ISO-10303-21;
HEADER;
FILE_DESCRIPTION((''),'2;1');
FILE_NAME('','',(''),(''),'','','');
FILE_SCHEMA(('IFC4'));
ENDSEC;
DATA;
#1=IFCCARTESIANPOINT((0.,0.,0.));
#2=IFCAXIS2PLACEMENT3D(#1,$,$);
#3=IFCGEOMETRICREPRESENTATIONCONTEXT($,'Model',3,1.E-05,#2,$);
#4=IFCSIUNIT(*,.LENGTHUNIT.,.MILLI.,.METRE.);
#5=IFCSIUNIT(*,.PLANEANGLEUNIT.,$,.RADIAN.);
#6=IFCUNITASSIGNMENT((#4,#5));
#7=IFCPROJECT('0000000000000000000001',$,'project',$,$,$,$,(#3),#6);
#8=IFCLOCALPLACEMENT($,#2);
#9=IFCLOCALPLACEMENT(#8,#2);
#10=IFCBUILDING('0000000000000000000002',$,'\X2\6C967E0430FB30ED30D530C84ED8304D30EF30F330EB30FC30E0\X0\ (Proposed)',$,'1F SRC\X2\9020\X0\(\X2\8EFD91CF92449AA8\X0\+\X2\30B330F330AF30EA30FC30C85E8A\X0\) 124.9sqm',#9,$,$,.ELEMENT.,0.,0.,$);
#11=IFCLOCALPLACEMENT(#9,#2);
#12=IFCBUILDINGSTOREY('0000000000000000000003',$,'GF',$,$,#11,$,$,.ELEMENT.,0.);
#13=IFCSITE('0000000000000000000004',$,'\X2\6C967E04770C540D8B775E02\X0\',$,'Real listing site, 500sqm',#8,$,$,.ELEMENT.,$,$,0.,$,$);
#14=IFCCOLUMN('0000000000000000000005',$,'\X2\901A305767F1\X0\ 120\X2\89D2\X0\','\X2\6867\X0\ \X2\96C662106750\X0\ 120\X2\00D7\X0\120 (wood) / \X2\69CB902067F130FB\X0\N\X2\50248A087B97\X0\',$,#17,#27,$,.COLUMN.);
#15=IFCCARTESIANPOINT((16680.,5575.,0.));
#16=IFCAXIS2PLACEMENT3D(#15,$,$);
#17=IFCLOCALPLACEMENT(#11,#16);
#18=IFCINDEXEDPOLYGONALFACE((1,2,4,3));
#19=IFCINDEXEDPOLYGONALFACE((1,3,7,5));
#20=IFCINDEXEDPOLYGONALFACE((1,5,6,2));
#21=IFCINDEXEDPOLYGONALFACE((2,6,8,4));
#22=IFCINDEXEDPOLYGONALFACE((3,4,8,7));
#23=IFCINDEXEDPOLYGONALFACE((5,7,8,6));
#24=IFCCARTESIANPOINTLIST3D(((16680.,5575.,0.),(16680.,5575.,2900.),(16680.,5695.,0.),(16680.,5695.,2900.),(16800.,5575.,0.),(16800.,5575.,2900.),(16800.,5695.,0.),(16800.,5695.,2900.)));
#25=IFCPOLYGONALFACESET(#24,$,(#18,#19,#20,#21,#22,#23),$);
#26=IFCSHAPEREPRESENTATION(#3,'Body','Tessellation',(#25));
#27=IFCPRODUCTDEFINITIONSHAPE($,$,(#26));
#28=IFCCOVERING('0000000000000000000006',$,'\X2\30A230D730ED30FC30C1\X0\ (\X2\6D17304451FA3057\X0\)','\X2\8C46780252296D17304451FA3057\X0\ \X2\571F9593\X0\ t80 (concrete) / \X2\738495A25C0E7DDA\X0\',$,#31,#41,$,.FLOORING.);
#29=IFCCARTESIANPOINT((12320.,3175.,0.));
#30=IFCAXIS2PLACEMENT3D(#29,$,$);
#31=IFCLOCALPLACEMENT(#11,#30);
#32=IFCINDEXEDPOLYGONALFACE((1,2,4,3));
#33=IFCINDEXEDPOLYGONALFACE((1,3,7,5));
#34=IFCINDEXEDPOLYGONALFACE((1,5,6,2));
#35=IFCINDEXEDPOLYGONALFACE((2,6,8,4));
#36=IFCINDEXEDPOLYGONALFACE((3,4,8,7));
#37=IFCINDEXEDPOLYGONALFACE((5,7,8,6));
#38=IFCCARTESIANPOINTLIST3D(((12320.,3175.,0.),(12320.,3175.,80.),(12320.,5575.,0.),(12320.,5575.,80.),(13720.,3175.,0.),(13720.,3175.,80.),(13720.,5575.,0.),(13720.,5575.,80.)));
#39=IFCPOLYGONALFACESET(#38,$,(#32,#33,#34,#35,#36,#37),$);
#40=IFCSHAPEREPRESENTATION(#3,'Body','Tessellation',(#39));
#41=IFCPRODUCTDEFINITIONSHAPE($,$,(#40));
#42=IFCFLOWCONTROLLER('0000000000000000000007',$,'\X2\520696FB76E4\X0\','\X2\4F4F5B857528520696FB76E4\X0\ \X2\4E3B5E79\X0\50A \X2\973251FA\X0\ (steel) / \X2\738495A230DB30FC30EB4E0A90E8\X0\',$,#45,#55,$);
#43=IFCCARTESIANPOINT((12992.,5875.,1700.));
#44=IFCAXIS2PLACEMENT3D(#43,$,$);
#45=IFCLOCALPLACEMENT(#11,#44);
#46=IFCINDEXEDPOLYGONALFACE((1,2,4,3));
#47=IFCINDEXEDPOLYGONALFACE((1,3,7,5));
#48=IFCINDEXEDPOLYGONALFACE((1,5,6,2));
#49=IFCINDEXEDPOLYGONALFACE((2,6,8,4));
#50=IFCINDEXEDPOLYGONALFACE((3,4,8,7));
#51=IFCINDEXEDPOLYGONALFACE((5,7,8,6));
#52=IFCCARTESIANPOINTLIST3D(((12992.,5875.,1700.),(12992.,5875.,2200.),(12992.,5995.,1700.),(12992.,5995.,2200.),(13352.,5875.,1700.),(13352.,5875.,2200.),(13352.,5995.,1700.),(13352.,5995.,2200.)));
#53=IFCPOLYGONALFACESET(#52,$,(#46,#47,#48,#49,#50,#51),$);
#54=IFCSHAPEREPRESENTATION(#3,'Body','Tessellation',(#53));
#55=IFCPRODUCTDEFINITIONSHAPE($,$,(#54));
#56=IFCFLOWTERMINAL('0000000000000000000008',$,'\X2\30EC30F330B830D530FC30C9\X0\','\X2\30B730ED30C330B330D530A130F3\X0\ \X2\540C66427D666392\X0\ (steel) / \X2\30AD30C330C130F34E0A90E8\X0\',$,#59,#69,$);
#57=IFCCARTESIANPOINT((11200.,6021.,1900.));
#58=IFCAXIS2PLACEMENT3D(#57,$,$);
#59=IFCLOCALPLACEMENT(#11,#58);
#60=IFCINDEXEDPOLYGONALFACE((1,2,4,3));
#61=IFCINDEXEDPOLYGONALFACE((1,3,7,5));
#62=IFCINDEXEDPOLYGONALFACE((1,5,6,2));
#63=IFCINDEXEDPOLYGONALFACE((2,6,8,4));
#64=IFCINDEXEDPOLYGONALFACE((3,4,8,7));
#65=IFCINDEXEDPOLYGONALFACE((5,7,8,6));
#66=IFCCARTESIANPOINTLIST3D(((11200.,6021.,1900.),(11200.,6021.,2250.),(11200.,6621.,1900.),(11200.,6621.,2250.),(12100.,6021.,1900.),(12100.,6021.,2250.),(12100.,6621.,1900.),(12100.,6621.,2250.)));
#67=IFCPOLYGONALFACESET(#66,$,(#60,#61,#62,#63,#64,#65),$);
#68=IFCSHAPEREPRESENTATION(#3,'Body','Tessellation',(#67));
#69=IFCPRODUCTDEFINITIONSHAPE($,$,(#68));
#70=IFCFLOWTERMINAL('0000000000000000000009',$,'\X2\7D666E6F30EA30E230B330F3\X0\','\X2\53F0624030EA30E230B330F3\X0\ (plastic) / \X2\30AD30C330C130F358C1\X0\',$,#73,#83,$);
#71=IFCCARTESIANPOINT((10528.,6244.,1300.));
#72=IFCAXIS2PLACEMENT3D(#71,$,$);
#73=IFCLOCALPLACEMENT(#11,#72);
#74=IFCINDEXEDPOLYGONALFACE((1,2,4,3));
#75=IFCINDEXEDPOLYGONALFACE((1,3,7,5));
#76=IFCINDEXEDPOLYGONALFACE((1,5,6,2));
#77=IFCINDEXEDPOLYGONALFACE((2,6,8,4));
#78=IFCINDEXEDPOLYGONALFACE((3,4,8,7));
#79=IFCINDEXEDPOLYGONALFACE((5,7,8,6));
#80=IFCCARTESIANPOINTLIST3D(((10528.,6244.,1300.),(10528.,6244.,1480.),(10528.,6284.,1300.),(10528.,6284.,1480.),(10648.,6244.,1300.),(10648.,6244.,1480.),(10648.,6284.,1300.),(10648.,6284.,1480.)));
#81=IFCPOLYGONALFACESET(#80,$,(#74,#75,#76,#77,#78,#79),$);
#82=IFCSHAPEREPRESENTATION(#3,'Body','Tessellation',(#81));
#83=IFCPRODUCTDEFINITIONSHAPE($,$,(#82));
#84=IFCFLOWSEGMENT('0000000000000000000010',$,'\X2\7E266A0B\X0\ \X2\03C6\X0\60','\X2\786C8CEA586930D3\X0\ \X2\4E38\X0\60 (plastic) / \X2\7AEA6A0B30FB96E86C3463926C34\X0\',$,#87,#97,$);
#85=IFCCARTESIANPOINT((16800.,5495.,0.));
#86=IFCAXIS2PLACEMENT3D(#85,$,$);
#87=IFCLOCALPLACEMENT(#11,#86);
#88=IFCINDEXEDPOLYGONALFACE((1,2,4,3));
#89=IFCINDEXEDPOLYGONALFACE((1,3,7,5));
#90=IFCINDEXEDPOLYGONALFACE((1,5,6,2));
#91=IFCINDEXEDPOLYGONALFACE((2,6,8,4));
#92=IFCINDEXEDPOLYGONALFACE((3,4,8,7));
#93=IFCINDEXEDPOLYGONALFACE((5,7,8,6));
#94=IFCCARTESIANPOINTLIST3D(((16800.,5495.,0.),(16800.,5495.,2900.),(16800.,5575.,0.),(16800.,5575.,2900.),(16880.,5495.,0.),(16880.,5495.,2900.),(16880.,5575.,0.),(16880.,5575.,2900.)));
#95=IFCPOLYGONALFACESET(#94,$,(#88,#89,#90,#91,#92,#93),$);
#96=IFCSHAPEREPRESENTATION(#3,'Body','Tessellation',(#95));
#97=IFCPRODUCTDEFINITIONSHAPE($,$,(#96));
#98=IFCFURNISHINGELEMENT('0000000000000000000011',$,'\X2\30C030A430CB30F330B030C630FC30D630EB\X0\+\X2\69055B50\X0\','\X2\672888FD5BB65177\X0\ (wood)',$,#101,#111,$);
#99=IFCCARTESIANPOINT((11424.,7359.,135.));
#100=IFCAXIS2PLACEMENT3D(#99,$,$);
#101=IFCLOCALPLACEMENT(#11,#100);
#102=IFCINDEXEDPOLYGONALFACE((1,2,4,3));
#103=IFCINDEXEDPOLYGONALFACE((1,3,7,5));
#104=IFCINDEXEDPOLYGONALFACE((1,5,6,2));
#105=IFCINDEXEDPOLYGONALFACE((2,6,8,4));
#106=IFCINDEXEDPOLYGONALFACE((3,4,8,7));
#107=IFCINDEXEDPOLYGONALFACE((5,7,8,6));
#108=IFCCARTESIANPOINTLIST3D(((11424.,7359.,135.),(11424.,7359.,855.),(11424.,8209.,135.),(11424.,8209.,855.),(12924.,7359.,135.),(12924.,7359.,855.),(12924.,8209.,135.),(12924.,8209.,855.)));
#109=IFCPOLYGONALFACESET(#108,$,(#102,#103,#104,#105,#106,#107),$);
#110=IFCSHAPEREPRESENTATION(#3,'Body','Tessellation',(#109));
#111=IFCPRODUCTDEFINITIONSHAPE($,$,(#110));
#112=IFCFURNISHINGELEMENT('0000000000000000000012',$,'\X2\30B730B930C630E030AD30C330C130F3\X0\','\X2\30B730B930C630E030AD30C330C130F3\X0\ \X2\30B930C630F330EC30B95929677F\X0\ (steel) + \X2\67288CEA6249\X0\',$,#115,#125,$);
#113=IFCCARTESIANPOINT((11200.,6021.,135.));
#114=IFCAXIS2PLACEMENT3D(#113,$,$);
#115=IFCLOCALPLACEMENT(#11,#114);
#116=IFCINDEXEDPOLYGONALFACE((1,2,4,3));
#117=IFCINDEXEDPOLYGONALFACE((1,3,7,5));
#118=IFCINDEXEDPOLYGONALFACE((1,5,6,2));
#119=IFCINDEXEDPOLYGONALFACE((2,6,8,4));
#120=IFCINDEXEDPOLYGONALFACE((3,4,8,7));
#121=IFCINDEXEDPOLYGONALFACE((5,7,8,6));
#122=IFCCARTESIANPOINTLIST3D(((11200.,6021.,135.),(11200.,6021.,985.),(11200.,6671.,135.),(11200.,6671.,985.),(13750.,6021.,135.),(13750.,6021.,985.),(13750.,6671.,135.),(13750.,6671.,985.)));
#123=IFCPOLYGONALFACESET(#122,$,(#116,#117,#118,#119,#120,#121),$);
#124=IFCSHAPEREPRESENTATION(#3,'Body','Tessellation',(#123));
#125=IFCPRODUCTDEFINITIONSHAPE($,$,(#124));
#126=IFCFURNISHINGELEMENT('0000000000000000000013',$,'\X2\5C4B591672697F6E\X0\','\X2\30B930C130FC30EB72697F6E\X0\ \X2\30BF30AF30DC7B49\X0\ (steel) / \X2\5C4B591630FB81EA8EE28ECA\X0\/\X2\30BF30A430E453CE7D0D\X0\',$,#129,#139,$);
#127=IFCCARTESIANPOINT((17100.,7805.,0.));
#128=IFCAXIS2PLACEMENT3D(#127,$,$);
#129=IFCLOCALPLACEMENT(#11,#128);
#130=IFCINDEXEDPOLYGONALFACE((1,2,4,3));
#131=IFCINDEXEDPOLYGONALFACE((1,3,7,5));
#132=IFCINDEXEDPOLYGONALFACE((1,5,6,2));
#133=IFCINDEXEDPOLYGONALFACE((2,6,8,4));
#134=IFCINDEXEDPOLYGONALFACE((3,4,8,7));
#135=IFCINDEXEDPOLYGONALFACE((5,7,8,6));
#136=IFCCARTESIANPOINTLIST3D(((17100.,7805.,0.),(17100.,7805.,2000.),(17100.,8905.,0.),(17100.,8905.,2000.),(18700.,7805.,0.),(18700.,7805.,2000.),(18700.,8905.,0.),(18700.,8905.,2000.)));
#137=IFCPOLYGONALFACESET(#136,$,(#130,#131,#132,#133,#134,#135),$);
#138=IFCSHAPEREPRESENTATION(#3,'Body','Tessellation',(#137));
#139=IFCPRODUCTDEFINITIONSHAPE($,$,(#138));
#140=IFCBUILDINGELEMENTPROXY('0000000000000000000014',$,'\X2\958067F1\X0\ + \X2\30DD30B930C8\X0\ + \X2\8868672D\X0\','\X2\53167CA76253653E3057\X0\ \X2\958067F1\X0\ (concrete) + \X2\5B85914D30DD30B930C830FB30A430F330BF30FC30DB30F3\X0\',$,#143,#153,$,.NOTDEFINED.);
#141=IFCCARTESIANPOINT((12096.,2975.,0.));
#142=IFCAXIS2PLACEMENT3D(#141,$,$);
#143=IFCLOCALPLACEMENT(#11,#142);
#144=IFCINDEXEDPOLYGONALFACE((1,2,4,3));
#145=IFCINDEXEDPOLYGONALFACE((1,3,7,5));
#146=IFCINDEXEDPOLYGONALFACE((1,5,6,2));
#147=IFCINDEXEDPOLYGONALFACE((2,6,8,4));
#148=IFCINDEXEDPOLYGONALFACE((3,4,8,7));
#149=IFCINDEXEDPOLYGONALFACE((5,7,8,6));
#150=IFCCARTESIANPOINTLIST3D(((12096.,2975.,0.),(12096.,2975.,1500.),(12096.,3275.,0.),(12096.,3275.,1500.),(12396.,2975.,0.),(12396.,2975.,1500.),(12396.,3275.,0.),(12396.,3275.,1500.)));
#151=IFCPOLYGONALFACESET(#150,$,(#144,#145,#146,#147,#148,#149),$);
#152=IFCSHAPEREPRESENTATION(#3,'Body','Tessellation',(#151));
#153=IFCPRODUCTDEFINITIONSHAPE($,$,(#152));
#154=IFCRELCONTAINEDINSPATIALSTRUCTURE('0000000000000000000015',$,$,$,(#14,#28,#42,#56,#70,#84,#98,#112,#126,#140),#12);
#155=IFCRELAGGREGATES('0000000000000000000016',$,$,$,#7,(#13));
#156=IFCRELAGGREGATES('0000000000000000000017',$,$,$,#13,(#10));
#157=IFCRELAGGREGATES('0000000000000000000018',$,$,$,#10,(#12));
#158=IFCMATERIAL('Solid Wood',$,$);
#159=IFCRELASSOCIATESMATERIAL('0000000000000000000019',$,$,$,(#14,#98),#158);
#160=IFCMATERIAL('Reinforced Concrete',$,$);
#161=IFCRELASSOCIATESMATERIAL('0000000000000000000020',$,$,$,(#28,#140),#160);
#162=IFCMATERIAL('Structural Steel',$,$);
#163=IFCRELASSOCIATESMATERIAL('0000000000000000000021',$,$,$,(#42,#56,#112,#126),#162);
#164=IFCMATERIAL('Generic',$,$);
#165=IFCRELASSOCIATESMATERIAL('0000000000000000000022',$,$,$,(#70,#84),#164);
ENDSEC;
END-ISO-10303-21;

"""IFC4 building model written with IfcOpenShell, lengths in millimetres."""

from ifc_helpers import new_model, si_unit, frame, frame_2d, origin, place, context, project, spatial, rectangle, extrude, material, element, save


model = new_model("IFC4")

# Units and contexts
model_context = context("Model", 3, precision=1e-05, world=origin())
ifc_project = project(units=[si_unit("LENGTHUNIT", "METRE", prefix="MILLI"), si_unit("PLANEANGLEUNIT", "RADIAN")], contexts=[model_context])

# Site, building, storey
site_placement = place(None, origin())
site = spatial("IfcSite", under=ifc_project, at=site_placement, Name="沖縄県名護市", ObjectType="Real listing site, 500sqm", CompositionType="ELEMENT", RefElevation=0.0)
building_placement = place(site_placement, origin())
building = spatial("IfcBuilding", under=site, at=building_placement, Name="沖縄・ロフト付きワンルーム (Proposed)", ObjectType="1F SRC造(軽量鉄骨+コンクリート床) 124.9sqm", CompositionType="ELEMENT", ElevationOfRefHeight=0.0, ElevationOfTerrain=0.0)
storey_placement = place(building_placement, origin())
storey = spatial("IfcBuildingStorey", under=building, at=storey_placement, Name="GF", CompositionType="ELEMENT", Elevation=0.0)

# Column
ifc_material_1 = material(Name="Solid Wood")
column_1_placement = place(storey_placement, frame((16680.0, 5575.0, 0.0)))
element("IfcColumn", 1, at=column_1_placement, inside=storey, material=ifc_material_1, Name="通し柱 120角", Description="桧 集成材 120×120 (wood) / 構造柱・N値計算", PredefinedType="COLUMN", context=model_context, shape_type="SweptSolid", body=[
    extrude(rectangle(XDim=120.0, YDim=120.0, at=frame_2d((60.0, 60.0))), frame((16680.0, 5575.0, 0.0)), (0.0, 0.0, 1.0), 2900.0),
])

# Covering
ifc_material_2 = material(Name="Reinforced Concrete")
covering_placement = place(storey_placement, frame((12320.0, 3175.0, 0.0)))
element("IfcCovering", 2, at=covering_placement, inside=storey, material=ifc_material_2, Name="アプローチ (洗い出し)", Description="豆砂利洗い出し 土間 t80 (concrete) / 玄関導線", PredefinedType="FLOORING", context=model_context, shape_type="SweptSolid", body=[
    extrude(rectangle(XDim=1400.0, YDim=2400.0, at=frame_2d((700.0, 1200.0))), frame((12320.0, 3175.0, 0.0)), (0.0, 0.0, 1.0), 80.0),
])

# Flow controller
ifc_material_3 = material(Name="Structural Steel")
flow_controller_placement = place(storey_placement, frame((12992.0, 5875.0, 1700.0)))
element("IfcFlowController", 3, at=flow_controller_placement, inside=storey, material=ifc_material_3, Name="分電盤", Description="住宅用分電盤 主幹50A 露出 (steel) / 玄関ホール上部", context=model_context, shape_type="SweptSolid", body=[
    extrude(rectangle(XDim=360.0, YDim=120.0, at=frame_2d((180.0, 60.0))), frame((12992.0, 5875.0, 1700.0)), (0.0, 0.0, 1.0), 500.0),
])

# Flow terminals
flow_terminal_1_placement = place(storey_placement, frame((11200.0, 6021.0, 1900.0)))
element("IfcFlowTerminal", 4, at=flow_terminal_1_placement, inside=storey, material=ifc_material_3, Name="レンジフード", Description="シロッコファン 同時給排 (steel) / キッチン上部", context=model_context, shape_type="SweptSolid", body=[
    extrude(rectangle(XDim=900.0, YDim=600.0, at=frame_2d((450.0, 300.0))), frame((11200.0, 6021.0, 1900.0)), (0.0, 0.0, 1.0), 350.0),
])
ifc_material_4 = material(Name="Generic")
flow_terminal_2_placement = place(storey_placement, frame((10528.0, 6244.0, 1300.0)))
element("IfcFlowTerminal", 5, at=flow_terminal_2_placement, inside=storey, material=ifc_material_4, Name="給湯リモコン", Description="台所リモコン (plastic) / キッチン壁", context=model_context, shape_type="SweptSolid", body=[
    extrude(rectangle(XDim=120.0, YDim=40.0, at=frame_2d((60.0, 20.0))), frame((10528.0, 6244.0, 1300.0)), (0.0, 0.0, 1.0), 180.0),
])

# Flow segment
flow_segment_placement = place(storey_placement, frame((16800.0, 5495.0, 0.0)))
element("IfcFlowSegment", 6, at=flow_segment_placement, inside=storey, material=ifc_material_4, Name="縦樋 φ60", Description="硬質塩ビ 丸60 (plastic) / 竪樋・雨水排水", context=model_context, shape_type="SweptSolid", body=[
    extrude(rectangle(XDim=80.0, YDim=80.0, at=frame_2d((40.0, 40.0))), frame((16800.0, 5495.0, 0.0)), (0.0, 0.0, 1.0), 2900.0),
])

# Furnishing elements
furnishing_1_placement = place(storey_placement, frame((11424.0, 7359.0, 135.0)))
element("IfcFurnishingElement", 7, at=furnishing_1_placement, inside=storey, material=ifc_material_1, Name="ダイニングテーブル+椅子", Description="木製家具 (wood)", context=model_context, shape_type="SweptSolid", body=[
    extrude(rectangle(XDim=1500.0, YDim=850.0, at=frame_2d((750.0, 425.0))), frame((11424.0, 7359.0, 135.0)), (0.0, 0.0, 1.0), 720.0),
])
furnishing_2_placement = place(storey_placement, frame((11200.0, 6021.0, 135.0)))
element("IfcFurnishingElement", 8, at=furnishing_2_placement, inside=storey, material=ifc_material_3, Name="システムキッチン", Description="システムキッチン ステンレス天板 (steel) + 木質扉", context=model_context, shape_type="SweptSolid", body=[
    extrude(rectangle(XDim=2550.0, YDim=650.0, at=frame_2d((1275.0, 325.0))), frame((11200.0, 6021.0, 135.0)), (0.0, 0.0, 1.0), 850.0),
])
furnishing_3_placement = place(storey_placement, frame((17100.0, 7805.0, 0.0)))
element("IfcFurnishingElement", 9, at=furnishing_3_placement, inside=storey, material=ifc_material_3, Name="屋外物置", Description="スチール物置 タクボ等 (steel) / 屋外・自転車/タイヤ収納", context=model_context, shape_type="SweptSolid", body=[
    extrude(rectangle(XDim=1600.0, YDim=1100.0, at=frame_2d((800.0, 550.0))), frame((17100.0, 7805.0, 0.0)), (0.0, 0.0, 1.0), 2000.0),
])

# Building element proxy
proxy_placement = place(storey_placement, frame((12096.0, 2975.0, 0.0)))
element("IfcBuildingElementProxy", 10, at=proxy_placement, inside=storey, material=ifc_material_2, Name="門柱 + ポスト + 表札", Description="化粧打放し 門柱 (concrete) + 宅配ポスト・インターホン", PredefinedType="NOTDEFINED", context=model_context, shape_type="SweptSolid", body=[
    extrude(rectangle(XDim=300.0, YDim=300.0, at=frame_2d((150.0, 150.0))), frame((12096.0, 2975.0, 0.0)), (0.0, 0.0, 1.0), 1500.0),
])

save(model, "model.ifc")
